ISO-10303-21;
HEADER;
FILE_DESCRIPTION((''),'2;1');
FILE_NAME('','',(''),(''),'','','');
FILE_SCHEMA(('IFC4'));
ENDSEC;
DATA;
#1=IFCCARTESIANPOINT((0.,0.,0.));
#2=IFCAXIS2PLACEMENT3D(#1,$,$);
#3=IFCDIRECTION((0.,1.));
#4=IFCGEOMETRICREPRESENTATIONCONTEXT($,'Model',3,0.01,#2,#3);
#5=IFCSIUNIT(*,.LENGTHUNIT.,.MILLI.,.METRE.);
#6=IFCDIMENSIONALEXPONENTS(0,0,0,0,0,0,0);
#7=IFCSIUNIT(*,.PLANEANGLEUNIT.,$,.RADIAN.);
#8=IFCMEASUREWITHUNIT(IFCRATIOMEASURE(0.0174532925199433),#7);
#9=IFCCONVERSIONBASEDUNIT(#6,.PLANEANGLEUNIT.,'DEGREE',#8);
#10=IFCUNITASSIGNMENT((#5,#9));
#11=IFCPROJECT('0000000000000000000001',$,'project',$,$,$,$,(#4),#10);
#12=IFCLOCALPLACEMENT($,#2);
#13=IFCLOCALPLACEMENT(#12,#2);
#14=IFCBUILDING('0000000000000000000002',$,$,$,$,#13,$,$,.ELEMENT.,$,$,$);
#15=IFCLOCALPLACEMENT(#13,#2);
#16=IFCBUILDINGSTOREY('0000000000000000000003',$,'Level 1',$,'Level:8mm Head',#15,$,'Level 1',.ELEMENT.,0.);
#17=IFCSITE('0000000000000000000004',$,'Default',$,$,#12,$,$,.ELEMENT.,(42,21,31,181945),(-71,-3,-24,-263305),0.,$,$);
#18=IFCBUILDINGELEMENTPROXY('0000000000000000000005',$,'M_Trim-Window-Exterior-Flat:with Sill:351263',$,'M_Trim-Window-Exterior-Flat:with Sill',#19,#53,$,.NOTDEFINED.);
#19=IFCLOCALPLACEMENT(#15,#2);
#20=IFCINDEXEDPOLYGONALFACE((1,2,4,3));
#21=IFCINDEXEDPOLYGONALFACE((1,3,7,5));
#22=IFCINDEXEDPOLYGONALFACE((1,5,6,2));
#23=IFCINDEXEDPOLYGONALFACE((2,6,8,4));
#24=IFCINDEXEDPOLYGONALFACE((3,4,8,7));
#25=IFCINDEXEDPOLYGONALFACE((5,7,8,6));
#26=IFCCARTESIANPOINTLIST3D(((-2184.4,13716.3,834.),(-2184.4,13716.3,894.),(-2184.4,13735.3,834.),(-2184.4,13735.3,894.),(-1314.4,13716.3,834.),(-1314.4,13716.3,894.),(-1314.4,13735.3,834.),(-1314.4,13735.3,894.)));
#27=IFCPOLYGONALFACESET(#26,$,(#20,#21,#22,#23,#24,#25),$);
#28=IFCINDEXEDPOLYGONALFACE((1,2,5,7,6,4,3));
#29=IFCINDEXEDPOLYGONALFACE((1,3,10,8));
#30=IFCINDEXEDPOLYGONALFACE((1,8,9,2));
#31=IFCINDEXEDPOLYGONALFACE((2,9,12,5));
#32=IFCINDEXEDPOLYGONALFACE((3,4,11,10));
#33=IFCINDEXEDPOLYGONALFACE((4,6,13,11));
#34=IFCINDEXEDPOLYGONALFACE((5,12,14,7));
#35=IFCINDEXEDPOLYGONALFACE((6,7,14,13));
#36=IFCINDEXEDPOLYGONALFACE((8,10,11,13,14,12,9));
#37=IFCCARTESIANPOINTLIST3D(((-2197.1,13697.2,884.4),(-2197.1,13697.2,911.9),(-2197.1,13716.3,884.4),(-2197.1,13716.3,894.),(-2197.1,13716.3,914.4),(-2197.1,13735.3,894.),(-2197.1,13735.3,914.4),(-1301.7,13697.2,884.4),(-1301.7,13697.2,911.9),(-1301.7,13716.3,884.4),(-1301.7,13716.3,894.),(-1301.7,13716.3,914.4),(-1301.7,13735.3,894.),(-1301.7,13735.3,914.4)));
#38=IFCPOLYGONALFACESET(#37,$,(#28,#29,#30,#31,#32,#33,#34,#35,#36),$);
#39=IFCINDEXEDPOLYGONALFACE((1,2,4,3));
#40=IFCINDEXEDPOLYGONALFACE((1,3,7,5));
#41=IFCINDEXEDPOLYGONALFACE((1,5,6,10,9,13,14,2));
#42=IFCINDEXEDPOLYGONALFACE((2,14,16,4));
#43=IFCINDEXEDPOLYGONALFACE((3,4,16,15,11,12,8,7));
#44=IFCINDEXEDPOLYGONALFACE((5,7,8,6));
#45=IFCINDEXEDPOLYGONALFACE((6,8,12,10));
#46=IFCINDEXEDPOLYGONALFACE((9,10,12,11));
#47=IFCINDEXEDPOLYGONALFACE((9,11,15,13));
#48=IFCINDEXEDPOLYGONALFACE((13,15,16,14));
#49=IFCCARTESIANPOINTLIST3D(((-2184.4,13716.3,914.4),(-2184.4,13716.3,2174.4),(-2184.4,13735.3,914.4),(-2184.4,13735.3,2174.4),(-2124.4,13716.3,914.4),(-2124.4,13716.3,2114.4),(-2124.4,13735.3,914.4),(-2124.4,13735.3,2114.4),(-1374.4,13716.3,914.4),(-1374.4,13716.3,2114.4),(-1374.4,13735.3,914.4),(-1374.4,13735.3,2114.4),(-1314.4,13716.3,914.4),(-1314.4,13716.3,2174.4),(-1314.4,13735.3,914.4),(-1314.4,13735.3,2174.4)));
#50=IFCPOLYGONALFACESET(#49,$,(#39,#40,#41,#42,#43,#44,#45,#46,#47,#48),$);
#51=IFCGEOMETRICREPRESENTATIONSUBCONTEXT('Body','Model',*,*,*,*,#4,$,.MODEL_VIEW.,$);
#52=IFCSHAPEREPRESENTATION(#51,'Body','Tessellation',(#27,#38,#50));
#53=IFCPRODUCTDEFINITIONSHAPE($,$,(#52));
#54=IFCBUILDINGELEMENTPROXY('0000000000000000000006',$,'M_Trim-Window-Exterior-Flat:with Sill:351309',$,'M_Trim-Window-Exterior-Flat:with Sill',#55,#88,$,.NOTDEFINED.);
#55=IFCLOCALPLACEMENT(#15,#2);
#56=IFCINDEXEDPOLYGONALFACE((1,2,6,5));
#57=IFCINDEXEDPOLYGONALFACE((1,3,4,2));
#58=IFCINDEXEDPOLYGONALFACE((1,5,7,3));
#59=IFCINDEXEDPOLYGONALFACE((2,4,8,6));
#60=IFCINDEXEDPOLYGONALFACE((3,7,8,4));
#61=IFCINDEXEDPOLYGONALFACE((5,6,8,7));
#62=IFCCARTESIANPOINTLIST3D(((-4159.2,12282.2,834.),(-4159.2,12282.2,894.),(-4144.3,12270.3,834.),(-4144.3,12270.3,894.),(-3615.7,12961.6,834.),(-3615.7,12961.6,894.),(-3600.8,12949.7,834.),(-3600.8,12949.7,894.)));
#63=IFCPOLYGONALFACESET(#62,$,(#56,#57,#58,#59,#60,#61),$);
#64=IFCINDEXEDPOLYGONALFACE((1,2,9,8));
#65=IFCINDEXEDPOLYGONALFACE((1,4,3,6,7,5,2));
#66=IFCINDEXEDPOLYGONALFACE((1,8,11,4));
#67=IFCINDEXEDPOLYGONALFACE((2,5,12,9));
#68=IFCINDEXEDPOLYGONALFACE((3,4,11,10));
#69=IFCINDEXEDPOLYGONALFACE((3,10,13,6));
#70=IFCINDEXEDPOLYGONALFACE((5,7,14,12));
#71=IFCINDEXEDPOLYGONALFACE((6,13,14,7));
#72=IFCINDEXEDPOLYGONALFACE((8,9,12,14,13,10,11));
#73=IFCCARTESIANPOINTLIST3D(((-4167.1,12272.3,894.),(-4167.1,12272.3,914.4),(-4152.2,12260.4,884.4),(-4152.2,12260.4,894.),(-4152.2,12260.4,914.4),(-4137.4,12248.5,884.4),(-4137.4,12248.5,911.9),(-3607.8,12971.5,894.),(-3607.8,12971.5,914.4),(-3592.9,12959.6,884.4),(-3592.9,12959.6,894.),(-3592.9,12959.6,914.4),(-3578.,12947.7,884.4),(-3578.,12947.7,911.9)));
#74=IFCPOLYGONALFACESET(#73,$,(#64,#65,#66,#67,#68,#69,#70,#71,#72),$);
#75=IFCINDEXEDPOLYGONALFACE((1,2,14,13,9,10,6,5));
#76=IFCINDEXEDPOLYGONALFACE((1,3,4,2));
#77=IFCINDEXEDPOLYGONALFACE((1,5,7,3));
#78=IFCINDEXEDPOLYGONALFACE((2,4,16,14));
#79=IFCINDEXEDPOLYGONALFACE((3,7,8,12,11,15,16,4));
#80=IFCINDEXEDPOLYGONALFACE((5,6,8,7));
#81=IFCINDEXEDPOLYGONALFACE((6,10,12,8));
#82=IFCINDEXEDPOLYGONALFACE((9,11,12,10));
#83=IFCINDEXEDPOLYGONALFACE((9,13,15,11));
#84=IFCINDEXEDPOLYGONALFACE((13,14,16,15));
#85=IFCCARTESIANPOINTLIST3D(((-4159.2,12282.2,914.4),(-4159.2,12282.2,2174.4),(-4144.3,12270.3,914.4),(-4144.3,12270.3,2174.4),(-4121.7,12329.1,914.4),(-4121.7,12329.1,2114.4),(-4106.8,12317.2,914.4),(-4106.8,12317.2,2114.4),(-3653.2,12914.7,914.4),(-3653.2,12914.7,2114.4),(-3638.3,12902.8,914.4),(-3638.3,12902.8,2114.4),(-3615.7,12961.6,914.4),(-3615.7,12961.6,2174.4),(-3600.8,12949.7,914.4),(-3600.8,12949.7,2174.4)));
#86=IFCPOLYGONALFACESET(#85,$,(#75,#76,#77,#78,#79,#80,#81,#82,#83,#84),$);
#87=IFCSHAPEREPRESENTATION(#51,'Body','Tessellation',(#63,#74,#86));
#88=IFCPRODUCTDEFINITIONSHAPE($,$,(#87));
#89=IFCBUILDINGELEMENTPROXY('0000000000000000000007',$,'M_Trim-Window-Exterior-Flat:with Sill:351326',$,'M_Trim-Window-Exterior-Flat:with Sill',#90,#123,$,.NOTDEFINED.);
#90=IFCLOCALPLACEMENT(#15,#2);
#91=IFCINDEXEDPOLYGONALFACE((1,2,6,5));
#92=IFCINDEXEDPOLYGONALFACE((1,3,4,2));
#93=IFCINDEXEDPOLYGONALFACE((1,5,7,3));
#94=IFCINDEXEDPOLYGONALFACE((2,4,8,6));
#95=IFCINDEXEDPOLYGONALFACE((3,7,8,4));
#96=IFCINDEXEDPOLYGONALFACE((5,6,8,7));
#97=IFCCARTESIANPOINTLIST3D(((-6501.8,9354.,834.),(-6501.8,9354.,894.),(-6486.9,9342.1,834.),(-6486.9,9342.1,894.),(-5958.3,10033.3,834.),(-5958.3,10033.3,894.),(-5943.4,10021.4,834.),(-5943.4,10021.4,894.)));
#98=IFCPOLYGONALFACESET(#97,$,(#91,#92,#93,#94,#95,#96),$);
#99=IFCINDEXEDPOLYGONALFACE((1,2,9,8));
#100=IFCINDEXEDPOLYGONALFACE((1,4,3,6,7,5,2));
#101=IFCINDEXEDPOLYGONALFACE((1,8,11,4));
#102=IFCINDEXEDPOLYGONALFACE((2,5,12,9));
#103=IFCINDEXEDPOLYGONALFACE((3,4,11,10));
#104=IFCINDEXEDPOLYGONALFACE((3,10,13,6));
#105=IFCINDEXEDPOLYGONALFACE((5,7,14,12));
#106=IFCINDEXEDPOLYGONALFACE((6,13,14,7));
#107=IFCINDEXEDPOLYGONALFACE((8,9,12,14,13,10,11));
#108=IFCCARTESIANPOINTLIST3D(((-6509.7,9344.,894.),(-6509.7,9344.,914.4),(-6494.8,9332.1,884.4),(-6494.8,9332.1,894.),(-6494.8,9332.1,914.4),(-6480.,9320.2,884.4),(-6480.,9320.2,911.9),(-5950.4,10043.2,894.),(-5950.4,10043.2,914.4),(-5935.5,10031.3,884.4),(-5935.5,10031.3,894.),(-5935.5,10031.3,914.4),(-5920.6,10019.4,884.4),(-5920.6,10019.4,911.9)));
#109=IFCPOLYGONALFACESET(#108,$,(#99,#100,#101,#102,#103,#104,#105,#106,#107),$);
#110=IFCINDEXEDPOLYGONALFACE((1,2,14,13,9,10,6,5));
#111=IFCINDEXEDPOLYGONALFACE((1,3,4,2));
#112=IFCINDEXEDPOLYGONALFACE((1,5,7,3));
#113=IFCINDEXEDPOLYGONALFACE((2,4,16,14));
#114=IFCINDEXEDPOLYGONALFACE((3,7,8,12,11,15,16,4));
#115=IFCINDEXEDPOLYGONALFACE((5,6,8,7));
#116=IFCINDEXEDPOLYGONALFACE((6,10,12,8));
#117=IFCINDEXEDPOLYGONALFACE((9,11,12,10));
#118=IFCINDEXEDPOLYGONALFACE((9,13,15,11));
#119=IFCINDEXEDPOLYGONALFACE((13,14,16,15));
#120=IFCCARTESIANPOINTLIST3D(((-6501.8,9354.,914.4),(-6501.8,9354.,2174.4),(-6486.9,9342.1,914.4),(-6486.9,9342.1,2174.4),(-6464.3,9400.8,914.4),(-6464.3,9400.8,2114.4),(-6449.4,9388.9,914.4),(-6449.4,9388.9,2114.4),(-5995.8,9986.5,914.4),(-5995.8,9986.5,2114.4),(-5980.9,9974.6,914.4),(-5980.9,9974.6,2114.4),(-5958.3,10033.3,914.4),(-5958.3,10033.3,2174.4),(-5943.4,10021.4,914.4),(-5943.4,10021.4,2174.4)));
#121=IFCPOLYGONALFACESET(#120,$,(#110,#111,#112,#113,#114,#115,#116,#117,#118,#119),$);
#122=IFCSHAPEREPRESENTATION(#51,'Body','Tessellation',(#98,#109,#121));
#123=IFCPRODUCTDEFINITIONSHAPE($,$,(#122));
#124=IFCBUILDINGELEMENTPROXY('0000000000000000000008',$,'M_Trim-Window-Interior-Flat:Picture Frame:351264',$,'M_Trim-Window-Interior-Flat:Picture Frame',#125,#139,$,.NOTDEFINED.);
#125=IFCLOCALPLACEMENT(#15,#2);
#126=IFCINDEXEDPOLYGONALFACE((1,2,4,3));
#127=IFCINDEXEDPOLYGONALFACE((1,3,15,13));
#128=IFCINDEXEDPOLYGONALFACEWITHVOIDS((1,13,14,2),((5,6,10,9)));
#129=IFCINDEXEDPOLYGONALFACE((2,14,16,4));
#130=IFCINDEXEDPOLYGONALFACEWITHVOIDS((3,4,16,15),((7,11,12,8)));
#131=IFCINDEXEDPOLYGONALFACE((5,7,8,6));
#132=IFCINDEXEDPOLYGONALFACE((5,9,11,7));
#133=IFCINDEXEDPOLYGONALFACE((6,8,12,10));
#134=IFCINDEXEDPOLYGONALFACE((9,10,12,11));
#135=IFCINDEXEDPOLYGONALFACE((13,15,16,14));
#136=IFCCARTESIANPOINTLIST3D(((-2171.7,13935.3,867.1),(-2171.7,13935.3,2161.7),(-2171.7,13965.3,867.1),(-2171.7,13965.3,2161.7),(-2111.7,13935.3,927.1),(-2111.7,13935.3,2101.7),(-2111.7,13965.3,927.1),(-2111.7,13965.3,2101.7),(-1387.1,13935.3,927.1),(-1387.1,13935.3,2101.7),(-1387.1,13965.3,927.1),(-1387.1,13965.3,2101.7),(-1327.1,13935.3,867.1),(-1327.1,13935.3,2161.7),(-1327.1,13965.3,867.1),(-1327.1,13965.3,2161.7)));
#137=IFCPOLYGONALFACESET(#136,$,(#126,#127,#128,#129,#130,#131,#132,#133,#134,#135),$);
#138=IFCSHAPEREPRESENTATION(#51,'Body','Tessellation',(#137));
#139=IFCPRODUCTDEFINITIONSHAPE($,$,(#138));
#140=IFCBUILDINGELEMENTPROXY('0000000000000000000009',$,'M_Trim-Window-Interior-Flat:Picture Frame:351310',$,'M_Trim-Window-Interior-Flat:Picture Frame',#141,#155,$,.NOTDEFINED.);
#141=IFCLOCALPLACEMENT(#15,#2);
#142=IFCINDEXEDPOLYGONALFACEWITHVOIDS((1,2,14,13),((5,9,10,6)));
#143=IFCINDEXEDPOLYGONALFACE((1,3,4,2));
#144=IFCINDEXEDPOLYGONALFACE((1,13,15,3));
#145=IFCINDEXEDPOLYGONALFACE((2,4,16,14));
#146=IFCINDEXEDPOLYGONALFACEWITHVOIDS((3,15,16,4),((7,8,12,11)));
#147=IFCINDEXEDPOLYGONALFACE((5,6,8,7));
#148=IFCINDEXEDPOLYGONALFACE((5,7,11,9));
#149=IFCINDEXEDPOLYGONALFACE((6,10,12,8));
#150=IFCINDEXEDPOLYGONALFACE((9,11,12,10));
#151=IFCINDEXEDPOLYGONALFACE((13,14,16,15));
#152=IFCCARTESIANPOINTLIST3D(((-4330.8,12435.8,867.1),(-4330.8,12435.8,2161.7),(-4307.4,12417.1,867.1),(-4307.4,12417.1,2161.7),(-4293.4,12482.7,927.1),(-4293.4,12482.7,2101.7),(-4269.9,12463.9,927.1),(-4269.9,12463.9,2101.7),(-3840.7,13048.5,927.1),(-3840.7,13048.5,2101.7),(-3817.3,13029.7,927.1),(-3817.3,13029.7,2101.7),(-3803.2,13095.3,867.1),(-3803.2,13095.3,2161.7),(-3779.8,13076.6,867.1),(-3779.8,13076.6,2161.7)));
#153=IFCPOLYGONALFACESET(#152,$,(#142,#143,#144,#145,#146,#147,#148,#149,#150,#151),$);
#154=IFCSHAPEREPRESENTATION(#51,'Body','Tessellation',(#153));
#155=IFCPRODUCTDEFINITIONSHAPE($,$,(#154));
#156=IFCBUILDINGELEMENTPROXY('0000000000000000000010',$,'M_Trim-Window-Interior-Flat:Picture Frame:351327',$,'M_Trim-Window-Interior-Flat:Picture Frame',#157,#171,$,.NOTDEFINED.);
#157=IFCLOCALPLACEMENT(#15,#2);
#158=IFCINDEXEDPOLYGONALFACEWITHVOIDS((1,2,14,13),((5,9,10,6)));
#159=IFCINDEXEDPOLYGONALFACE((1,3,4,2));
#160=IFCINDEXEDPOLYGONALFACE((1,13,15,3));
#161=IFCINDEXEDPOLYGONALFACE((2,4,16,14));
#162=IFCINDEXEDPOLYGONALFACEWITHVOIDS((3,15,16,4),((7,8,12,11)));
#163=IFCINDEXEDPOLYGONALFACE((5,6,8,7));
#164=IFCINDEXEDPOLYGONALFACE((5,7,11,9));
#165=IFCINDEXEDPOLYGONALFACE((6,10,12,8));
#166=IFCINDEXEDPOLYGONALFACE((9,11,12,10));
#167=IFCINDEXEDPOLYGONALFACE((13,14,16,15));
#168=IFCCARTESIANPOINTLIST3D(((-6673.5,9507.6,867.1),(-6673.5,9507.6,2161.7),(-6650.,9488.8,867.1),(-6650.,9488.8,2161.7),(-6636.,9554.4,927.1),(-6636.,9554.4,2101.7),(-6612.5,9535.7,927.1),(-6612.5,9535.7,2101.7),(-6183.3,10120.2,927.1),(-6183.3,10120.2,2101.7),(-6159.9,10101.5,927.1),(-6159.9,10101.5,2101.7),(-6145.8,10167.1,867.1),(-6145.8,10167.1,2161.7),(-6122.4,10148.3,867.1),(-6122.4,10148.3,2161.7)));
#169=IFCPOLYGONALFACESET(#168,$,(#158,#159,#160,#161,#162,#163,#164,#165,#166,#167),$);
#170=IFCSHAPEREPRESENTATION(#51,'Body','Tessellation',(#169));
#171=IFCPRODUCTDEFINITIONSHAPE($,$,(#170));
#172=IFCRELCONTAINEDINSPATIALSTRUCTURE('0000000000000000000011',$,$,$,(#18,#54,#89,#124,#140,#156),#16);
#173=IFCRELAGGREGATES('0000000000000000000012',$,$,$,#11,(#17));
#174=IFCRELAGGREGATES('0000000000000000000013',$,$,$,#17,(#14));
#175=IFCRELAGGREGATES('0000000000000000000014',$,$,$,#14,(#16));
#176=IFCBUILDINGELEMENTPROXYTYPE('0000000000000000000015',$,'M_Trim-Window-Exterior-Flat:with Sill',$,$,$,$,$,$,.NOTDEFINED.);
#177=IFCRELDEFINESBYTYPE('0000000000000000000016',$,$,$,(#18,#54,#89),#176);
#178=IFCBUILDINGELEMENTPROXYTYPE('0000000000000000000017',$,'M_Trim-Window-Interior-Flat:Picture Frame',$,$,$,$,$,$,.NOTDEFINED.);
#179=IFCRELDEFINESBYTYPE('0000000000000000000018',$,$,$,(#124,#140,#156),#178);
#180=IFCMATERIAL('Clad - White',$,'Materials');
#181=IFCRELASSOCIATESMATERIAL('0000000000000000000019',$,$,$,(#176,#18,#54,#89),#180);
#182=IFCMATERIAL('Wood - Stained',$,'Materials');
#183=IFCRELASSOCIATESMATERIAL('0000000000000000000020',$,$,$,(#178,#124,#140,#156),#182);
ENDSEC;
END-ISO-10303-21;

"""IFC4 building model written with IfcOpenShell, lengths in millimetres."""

from ifc_helpers import new_model, entity, si_unit, converted_unit, direction, frame, frame_2d, origin, place, context, subcontext, project, spatial, polyline, rectangle, outline, extrude, source, transform, mapped, material, type_object, type_shapes, element, save


model = new_model("IFC4")

# Units and contexts
model_context = context("Model", 3, precision=0.01, world=origin(), true_north=direction((0.0, 1.0)))
body_context = subcontext(model_context, "Body", "Model", "MODEL_VIEW")
ifc_project = project(units=[si_unit("LENGTHUNIT", "METRE", prefix="MILLI"), converted_unit("PLANEANGLEUNIT", "DEGREE", entity("IfcRatioMeasure", 0.0174532925199433), si_unit("PLANEANGLEUNIT", "RADIAN"), dimensions=[0, 0, 0, 0, 0, 0, 0])], contexts=[model_context])

# Site, building, storey
site_placement = place(None, origin())
site = spatial("IfcSite", under=ifc_project, at=site_placement, Name="Default", CompositionType="ELEMENT", RefLatitude=(42, 21, 31, 181945), RefLongitude=(-71, -3, -24, -263305), RefElevation=0.0)
building_placement = place(site_placement, origin())
building = spatial("IfcBuilding", under=site, at=building_placement, CompositionType="ELEMENT")
storey_placement = place(building_placement, origin())
storey = spatial("IfcBuildingStorey", under=building, at=storey_placement, Name="Level 1", ObjectType="Level:8mm Head", LongName="Level 1", CompositionType="ELEMENT", Elevation=0.0)

# Shared definitions
ifc_material_1 = material(Name="Wood - Stained", Category="Materials")

# Building element proxies
ifc_material_2 = material(Name="Clad - White", Category="Materials")
building_element_proxy_type_1 = type_object("IfcBuildingElementProxyType", Name="M_Trim-Window-Exterior-Flat:with Sill", PredefinedType="NOTDEFINED", material=ifc_material_2)
shared_shape_1 = source(origin(), body_context, "Body", "SweptSolid", [
    extrude(rectangle(XDim=870.0, YDim=60.0, at=frame_2d((0.0, 0.0), x_axis=(1.0, 0.0))), frame((0.0, -1250.4, 0.0), z_axis=(0.0, 0.0, 1.0), x_axis=(-1.0, 0.0, 0.0)), (0.0, 0.0, 1.0), 19.1),
    extrude(outline(polyline([(-19.0, -15.2), (0.0, -15.2), (0.0, -5.7), (19.0, -5.7), (19.0, 14.8), (0.0, 14.8), (-19.0, 12.3), (-19.0, -15.2)])), frame((-447.7, -1214.8, 19.0), z_axis=(1.0, 0.0, 0.0), x_axis=(0.0, 0.0, -1.0)), (0.0, 0.0, 1.0), 895.4),
    extrude(outline(polyline([(-645.0, -435.0), (615.0, -435.0), (615.0, -375.0), (-585.0, -375.0), (-585.0, 375.0), (615.0, 375.0), (615.0, 435.0), (-645.0, 435.0), (-645.0, -435.0)])), frame((0.0, -585.0, 0.0), z_axis=(0.0, 0.0, 1.0), x_axis=(0.0, -1.0, 0.0)), (0.0, 0.0, 1.0), 19.1),
])
type_shapes(building_element_proxy_type_1, [shared_shape_1])
for number, where, z_axis, x_axis, name in (
    (1, (-1749.4, 13735.3, 2114.4), (0.0, -1.0, 0.0), (1.0, 0.0, 0.0), "M_Trim-Window-Exterior-Flat:with Sill:351263"),
    (2, (-3887.4, 12621.9, 2114.4), (0.780869, -0.624695, 0.0), (0.624695, 0.780869, 0.0), "M_Trim-Window-Exterior-Flat:with Sill:351309"),
    (3, (-6230.0, 9693.6, 2114.4), (0.780869, -0.624695, 0.0), (0.624695, 0.780869, 0.0), "M_Trim-Window-Exterior-Flat:with Sill:351326"),
):
    element("IfcBuildingElementProxy", number, at=place(storey_placement, frame(where, z_axis=z_axis, x_axis=x_axis)), inside=storey, type_object=building_element_proxy_type_1, material=ifc_material_2, Name=name, ObjectType="M_Trim-Window-Exterior-Flat:with Sill", PredefinedType="NOTDEFINED", context=body_context, shape_type="MappedRepresentation", body=[
        mapped(shared_shape_1, transform((0.0, 0.0, 0.0), scale=1.0)),
    ])
building_element_proxy_type_2 = type_object("IfcBuildingElementProxyType", Name="M_Trim-Window-Interior-Flat:Picture Frame", PredefinedType="NOTDEFINED", material=ifc_material_1)
shared_shape_2 = source(origin(), body_context, "Body", "SweptSolid", [
    extrude(outline(polyline([(-422.3, -647.3), (422.3, -647.3), (422.3, 647.3), (-422.3, 647.3), (-422.3, -647.3)]), holes=[polyline([(-362.3, -587.3), (-362.3, 587.3), (362.3, 587.3), (362.3, -587.3), (-362.3, -587.3)])]), frame((0.0, -600.0, 0.0), z_axis=(0.0, 0.0, 1.0), x_axis=(-1.0, 0.0, 0.0)), (0.0, 0.0, 1.0), 30.0),
])
type_shapes(building_element_proxy_type_2, [shared_shape_2])
for number, where, z_axis, x_axis, name in (
    (4, (-1749.4, 13935.3, 2114.4), (0.0, 1.0, 0.0), (-1.0, 0.0, 0.0), "M_Trim-Window-Interior-Flat:Picture Frame:351264"),
    (5, (-4043.6, 12746.8, 2114.4), (-0.780869, 0.624695, 0.0), (-0.624695, -0.780869, 0.0), "M_Trim-Window-Interior-Flat:Picture Frame:351310"),
    (6, (-6386.2, 9818.6, 2114.4), (-0.780869, 0.624695, 0.0), (-0.624695, -0.780869, 0.0), "M_Trim-Window-Interior-Flat:Picture Frame:351327"),
):
    element("IfcBuildingElementProxy", number, at=place(storey_placement, frame(where, z_axis=z_axis, x_axis=x_axis)), inside=storey, type_object=building_element_proxy_type_2, material=ifc_material_1, Name=name, ObjectType="M_Trim-Window-Interior-Flat:Picture Frame", PredefinedType="NOTDEFINED", context=body_context, shape_type="MappedRepresentation", body=[
        mapped(shared_shape_2, transform((0.0, 0.0, 0.0), scale=1.0)),
    ])

save(model, "model.ifc")
